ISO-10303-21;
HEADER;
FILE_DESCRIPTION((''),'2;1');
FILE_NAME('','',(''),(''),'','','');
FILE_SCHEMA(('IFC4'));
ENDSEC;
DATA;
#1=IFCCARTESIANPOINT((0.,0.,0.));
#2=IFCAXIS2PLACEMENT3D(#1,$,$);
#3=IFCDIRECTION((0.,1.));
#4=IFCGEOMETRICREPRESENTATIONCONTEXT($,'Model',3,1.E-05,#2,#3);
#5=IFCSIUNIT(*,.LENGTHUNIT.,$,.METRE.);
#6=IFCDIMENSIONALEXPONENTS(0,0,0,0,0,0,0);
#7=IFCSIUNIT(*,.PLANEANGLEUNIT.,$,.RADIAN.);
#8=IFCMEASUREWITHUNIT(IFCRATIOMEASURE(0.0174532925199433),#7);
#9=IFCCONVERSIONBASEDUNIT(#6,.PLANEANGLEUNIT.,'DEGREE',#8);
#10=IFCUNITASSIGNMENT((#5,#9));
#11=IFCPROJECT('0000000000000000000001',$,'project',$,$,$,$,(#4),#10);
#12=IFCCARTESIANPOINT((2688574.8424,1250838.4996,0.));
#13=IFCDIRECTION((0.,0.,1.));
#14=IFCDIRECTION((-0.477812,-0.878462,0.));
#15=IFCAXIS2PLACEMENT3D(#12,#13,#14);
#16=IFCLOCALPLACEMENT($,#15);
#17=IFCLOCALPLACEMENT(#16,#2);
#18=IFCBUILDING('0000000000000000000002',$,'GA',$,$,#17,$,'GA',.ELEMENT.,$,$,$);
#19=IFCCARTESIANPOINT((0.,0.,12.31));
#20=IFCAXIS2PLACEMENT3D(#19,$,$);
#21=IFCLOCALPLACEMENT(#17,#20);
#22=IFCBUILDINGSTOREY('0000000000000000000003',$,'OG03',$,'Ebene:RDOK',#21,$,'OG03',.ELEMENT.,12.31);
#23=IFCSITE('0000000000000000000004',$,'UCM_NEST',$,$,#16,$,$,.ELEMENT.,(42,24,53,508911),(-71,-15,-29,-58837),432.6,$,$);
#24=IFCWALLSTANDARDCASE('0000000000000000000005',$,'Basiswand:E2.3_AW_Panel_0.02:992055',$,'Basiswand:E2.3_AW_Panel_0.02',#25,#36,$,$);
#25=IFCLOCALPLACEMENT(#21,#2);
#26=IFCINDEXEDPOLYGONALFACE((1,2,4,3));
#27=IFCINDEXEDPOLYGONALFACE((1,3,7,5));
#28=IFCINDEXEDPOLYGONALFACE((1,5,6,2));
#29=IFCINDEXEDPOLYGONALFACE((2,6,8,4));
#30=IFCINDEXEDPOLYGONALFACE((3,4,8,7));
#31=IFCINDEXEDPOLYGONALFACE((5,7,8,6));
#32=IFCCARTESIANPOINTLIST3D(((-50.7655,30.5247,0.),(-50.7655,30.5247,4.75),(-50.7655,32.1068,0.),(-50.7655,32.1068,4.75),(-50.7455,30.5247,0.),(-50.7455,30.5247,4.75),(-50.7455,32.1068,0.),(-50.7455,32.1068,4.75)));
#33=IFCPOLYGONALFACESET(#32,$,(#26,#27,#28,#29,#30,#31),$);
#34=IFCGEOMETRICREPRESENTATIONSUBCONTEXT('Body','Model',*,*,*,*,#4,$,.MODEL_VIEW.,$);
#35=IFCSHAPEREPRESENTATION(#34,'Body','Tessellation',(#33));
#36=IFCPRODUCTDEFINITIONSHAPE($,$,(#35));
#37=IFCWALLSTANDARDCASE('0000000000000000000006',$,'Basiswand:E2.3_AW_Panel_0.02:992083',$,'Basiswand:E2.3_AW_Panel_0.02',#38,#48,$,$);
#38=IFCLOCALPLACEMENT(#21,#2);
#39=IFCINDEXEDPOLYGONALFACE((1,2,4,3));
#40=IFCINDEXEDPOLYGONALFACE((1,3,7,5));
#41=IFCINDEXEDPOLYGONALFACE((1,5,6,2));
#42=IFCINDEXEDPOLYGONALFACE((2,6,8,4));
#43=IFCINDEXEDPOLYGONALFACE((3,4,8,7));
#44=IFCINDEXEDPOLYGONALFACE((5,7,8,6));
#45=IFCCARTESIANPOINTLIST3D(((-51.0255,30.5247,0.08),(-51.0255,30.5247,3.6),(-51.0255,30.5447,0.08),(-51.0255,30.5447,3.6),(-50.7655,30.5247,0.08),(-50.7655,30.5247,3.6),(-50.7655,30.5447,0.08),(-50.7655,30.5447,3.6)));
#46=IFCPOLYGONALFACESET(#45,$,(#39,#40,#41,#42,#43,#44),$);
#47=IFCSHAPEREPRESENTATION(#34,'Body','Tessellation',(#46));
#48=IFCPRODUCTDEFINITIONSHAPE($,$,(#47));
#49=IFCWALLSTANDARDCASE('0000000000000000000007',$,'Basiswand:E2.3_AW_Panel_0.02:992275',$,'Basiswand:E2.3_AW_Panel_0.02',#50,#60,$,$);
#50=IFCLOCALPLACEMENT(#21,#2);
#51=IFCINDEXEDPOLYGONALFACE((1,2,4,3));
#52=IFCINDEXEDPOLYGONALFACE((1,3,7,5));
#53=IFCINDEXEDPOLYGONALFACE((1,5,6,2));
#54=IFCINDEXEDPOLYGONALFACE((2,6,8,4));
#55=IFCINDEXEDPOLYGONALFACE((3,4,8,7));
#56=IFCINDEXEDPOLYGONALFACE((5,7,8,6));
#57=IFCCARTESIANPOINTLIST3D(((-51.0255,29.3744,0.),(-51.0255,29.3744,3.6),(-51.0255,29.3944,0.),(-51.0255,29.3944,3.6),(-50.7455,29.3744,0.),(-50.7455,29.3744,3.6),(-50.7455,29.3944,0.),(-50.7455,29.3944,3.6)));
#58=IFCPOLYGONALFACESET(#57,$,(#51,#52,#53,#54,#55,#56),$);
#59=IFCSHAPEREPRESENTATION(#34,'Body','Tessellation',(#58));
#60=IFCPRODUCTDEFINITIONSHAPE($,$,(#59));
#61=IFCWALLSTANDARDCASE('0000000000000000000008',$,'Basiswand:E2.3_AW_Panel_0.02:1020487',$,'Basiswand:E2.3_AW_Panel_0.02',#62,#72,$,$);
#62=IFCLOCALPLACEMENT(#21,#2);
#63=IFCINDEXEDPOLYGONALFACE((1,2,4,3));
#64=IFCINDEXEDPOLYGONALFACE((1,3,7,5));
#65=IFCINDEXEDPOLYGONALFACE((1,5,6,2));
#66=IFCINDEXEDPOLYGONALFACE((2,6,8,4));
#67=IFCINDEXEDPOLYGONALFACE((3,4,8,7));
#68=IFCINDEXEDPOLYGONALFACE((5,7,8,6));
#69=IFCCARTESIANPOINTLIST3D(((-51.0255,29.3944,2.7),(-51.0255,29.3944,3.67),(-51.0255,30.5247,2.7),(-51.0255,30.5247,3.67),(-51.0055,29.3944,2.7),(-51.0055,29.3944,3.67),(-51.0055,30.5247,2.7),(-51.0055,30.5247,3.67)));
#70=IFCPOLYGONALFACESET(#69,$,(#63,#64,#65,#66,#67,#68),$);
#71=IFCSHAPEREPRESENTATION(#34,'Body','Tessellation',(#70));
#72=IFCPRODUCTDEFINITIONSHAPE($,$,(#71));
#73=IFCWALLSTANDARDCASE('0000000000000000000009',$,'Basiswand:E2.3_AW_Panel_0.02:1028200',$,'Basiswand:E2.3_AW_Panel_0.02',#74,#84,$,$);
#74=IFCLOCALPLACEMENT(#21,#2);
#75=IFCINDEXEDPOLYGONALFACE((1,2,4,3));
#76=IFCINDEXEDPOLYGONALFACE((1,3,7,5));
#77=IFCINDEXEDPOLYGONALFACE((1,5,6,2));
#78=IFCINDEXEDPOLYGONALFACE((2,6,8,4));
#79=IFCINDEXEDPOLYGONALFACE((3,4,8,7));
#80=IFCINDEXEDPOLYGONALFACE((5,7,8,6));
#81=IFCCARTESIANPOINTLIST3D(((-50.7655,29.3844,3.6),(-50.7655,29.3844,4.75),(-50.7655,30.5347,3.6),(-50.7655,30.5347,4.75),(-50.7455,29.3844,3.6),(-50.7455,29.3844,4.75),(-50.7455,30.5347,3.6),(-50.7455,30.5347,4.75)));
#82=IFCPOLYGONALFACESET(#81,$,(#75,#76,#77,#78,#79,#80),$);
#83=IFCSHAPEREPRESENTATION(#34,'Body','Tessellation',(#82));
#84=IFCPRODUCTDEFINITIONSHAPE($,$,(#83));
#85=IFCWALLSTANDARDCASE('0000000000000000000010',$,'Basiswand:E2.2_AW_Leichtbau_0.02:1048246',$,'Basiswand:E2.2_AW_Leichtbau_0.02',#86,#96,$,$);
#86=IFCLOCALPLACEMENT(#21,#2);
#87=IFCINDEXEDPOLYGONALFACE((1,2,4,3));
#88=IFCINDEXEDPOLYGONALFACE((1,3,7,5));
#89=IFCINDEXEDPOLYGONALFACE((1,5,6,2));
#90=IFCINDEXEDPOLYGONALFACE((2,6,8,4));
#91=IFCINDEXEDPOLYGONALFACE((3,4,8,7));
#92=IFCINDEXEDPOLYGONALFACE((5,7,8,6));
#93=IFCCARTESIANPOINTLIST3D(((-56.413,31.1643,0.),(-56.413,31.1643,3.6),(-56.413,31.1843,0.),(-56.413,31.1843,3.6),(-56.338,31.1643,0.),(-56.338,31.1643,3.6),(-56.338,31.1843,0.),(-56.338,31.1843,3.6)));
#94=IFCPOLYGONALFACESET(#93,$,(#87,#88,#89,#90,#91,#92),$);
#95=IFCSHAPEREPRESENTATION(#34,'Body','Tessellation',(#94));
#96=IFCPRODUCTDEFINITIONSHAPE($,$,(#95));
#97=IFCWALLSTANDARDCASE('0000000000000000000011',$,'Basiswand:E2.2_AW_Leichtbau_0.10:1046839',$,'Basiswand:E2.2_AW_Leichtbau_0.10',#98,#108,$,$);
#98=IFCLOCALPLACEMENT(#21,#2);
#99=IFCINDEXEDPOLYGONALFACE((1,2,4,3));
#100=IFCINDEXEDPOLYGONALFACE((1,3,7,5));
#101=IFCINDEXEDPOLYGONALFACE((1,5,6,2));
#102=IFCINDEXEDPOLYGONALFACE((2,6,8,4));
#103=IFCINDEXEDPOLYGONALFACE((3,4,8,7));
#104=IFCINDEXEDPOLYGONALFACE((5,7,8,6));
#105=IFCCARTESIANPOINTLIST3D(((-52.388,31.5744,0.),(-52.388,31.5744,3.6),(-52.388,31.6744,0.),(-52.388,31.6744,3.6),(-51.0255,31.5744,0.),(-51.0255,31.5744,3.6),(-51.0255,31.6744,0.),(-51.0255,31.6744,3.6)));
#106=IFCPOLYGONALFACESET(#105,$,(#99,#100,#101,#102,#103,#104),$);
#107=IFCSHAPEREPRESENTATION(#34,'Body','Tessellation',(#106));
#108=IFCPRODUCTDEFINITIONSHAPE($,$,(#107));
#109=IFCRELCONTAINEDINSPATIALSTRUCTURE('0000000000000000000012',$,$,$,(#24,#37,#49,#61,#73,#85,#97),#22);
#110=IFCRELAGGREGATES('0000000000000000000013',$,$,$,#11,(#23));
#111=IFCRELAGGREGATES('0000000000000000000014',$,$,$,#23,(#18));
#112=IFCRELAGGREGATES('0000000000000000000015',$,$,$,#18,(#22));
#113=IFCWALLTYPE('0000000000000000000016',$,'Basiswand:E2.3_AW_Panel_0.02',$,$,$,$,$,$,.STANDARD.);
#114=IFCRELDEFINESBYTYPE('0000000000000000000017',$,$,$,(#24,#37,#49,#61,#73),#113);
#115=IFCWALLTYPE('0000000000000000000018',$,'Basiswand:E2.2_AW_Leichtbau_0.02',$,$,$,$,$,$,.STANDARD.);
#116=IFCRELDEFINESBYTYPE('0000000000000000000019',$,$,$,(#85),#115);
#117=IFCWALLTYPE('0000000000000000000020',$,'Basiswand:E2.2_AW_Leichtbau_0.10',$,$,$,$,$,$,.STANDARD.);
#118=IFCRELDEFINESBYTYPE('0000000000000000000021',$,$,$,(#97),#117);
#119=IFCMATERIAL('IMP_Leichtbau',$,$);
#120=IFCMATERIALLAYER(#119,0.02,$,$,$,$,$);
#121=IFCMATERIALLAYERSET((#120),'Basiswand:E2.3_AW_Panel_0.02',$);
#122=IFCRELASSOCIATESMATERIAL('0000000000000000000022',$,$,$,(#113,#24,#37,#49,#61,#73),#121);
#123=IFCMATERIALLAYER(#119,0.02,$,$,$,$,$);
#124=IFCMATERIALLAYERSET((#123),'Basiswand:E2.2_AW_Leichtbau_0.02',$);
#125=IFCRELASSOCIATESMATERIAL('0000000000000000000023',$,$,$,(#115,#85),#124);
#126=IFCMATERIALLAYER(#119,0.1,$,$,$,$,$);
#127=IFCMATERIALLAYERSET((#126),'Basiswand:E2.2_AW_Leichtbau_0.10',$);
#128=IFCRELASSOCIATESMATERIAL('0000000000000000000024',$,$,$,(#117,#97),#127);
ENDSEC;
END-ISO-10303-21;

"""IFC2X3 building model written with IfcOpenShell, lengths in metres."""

from ifc_helpers import new_model, entity, si_unit, converted_unit, direction, frame, frame_2d, origin, place, context, subcontext, project, spatial, polyline, rectangle, extrude, clip, bounded_halfspace, material, layer, layer_set, layer_usage, type_object, element, save


model = new_model("IFC2X3")

# Units and contexts
model_context = context("Model", 3, precision=1e-05, world=origin(), true_north=direction((0.0, 1.0)))
body_context = subcontext(model_context, "Body", "Model", "MODEL_VIEW")
ifc_project = project(units=[si_unit("LENGTHUNIT", "METRE"), converted_unit("PLANEANGLEUNIT", "DEGREE", entity("IfcRatioMeasure", 0.0174532925199433), si_unit("PLANEANGLEUNIT", "RADIAN"), dimensions=[0, 0, 0, 0, 0, 0, 0])], contexts=[model_context])

# Site, building, storey
site_placement = place(None, frame((2688574.8424, 1250838.4996, 0.0), z_axis=(0.0, 0.0, 1.0), x_axis=(-0.477812, -0.878462, 0.0)))
site = spatial("IfcSite", under=ifc_project, at=site_placement, Name="UCM_NEST", CompositionType="ELEMENT", RefLatitude=(42, 24, 53, 508911), RefLongitude=(-71, -15, -29, -58837), RefElevation=432.6)
building_placement = place(site_placement, origin())
building = spatial("IfcBuilding", under=site, at=building_placement, Name="GA", LongName="GA", CompositionType="ELEMENT")
storey_placement = place(building_placement, frame((0.0, 0.0, 12.31)))
storey = spatial("IfcBuildingStorey", under=building, at=storey_placement, Name="OG03", ObjectType="Ebene:RDOK", LongName="OG03", CompositionType="ELEMENT", Elevation=12.31)

# Walls
ifc_material_1 = material(Name="IMP_Leichtbau")
ifc_layer_1 = layer(ifc_material_1, 0.02)
ifc_layer_set_1 = layer_set([ifc_layer_1], Name="Basiswand:E2.3_AW_Panel_0.02")
wall_type_1 = type_object("IfcWallType", Name="Basiswand:E2.3_AW_Panel_0.02", PredefinedType="STANDARD", material=ifc_layer_set_1)
ifc_layer_usage_1 = layer_usage(ifc_layer_set_1, "AXIS2", "NEGATIVE", 0.01)
wall_1_placement = place(storey_placement, frame((-50.7555, 32.1068, 0.0), z_axis=(0.0, 0.0, 1.0), x_axis=(0.0, -1.0, 0.0)))
element("IfcWallStandardCase", 1, at=wall_1_placement, inside=storey, type_object=wall_type_1, material=ifc_layer_usage_1, Name="Basiswand:E2.3_AW_Panel_0.02:992055", ObjectType="Basiswand:E2.3_AW_Panel_0.02", context=body_context, shape_type="SweptSolid", body=[
    extrude(rectangle(XDim=1.5821, YDim=0.02, at=frame_2d((0.791, 0.0), x_axis=(-1.0, 0.0))), origin(), (0.0, 0.0, 1.0), 4.75),
])
ifc_layer_usage_2 = layer_usage(ifc_layer_set_1, "AXIS2", "NEGATIVE", 0.01)
wall_2_placement = place(storey_placement, frame((-50.7655, 30.5347, 0.08), z_axis=(0.0, 0.0, 1.0), x_axis=(-1.0, 0.0, 0.0)))
element("IfcWallStandardCase", 2, at=wall_2_placement, inside=storey, type_object=wall_type_1, material=ifc_layer_usage_2, Name="Basiswand:E2.3_AW_Panel_0.02:992083", ObjectType="Basiswand:E2.3_AW_Panel_0.02", context=body_context, shape_type="Clipping", body=[
    clip(extrude(rectangle(XDim=0.26, YDim=0.02, at=frame_2d((0.13, 0.0), x_axis=(-1.0, 0.0))), origin(), (0.0, 0.0, 1.0), 3.52), bounded_halfspace(frame((0.26, -0.01, 0.0)), True, frame((0.26, -0.01, 0.0)), polyline([(0.0, 0.0), (0.0, 0.02), (-0.26, 0.02), (-0.26, 0.0), (0.0, 0.0)]))),
])
ifc_layer_usage_3 = layer_usage(ifc_layer_set_1, "AXIS2", "NEGATIVE", 0.01)
wall_3_placement = place(storey_placement, frame((-51.0255, 29.3844, 0.0)))
element("IfcWallStandardCase", 3, at=wall_3_placement, inside=storey, type_object=wall_type_1, material=ifc_layer_usage_3, Name="Basiswand:E2.3_AW_Panel_0.02:992275", ObjectType="Basiswand:E2.3_AW_Panel_0.02", context=body_context, shape_type="SweptSolid", body=[
    extrude(rectangle(XDim=0.28, YDim=0.02, at=frame_2d((0.14, 0.0), x_axis=(-1.0, 0.0))), origin(), (0.0, 0.0, 1.0), 3.6),
])
ifc_layer_usage_4 = layer_usage(ifc_layer_set_1, "AXIS2", "NEGATIVE", 0.01)
wall_4_placement = place(storey_placement, frame((-51.0155, 30.5247, 2.7), z_axis=(0.0, 0.0, 1.0), x_axis=(0.0, -1.0, 0.0)))
element("IfcWallStandardCase", 4, at=wall_4_placement, inside=storey, type_object=wall_type_1, material=ifc_layer_usage_4, Name="Basiswand:E2.3_AW_Panel_0.02:1020487", ObjectType="Basiswand:E2.3_AW_Panel_0.02", context=body_context, shape_type="SweptSolid", body=[
    extrude(rectangle(XDim=1.1302, YDim=0.02, at=frame_2d((0.5651, 0.0), x_axis=(-1.0, 0.0))), origin(), (0.0, 0.0, 1.0), 0.97),
])
ifc_layer_usage_5 = layer_usage(ifc_layer_set_1, "AXIS2", "NEGATIVE", 0.01)
wall_5_placement = place(storey_placement, frame((-50.7555, 29.3844, 3.6), z_axis=(0.0, 0.0, 1.0), x_axis=(0.0, 1.0, 0.0)))
element("IfcWallStandardCase", 5, at=wall_5_placement, inside=storey, type_object=wall_type_1, material=ifc_layer_usage_5, Name="Basiswand:E2.3_AW_Panel_0.02:1028200", ObjectType="Basiswand:E2.3_AW_Panel_0.02", context=body_context, shape_type="SweptSolid", body=[
    extrude(rectangle(XDim=1.1502, YDim=0.02, at=frame_2d((0.5751, 0.0), x_axis=(-1.0, 0.0))), origin(), (0.0, 0.0, 1.0), 1.15),
])

# Walls
ifc_layer_2 = layer(ifc_material_1, 0.02)
ifc_layer_set_2 = layer_set([ifc_layer_2], Name="Basiswand:E2.2_AW_Leichtbau_0.02")
ifc_layer_usage_6 = layer_usage(ifc_layer_set_2, "AXIS2", "NEGATIVE", 0.01)
wall_type_2 = type_object("IfcWallType", Name="Basiswand:E2.2_AW_Leichtbau_0.02", PredefinedType="STANDARD", material=ifc_layer_set_2)
wall_6_placement = place(storey_placement, frame((-56.338, 31.1743, 0.0), z_axis=(0.0, 0.0, 1.0), x_axis=(-1.0, 0.0, 0.0)))
element("IfcWallStandardCase", 6, at=wall_6_placement, inside=storey, type_object=wall_type_2, material=ifc_layer_usage_6, Name="Basiswand:E2.2_AW_Leichtbau_0.02:1048246", ObjectType="Basiswand:E2.2_AW_Leichtbau_0.02", context=body_context, shape_type="SweptSolid", body=[
    extrude(rectangle(XDim=0.075, YDim=0.02, at=frame_2d((0.0375, 0.0), x_axis=(-1.0, 0.0))), origin(), (0.0, 0.0, 1.0), 3.6),
])
ifc_layer_3 = layer(ifc_material_1, 0.1)
ifc_layer_set_3 = layer_set([ifc_layer_3], Name="Basiswand:E2.2_AW_Leichtbau_0.10")
ifc_layer_usage_7 = layer_usage(ifc_layer_set_3, "AXIS2", "NEGATIVE", 0.05)
wall_type_3 = type_object("IfcWallType", Name="Basiswand:E2.2_AW_Leichtbau_0.10", PredefinedType="STANDARD", material=ifc_layer_set_3)
wall_7_placement = place(storey_placement, frame((-51.0255, 31.6244, 0.0), z_axis=(0.0, 0.0, 1.0), x_axis=(-1.0, 0.0, 0.0)))
element("IfcWallStandardCase", 7, at=wall_7_placement, inside=storey, type_object=wall_type_3, material=ifc_layer_usage_7, Name="Basiswand:E2.2_AW_Leichtbau_0.10:1046839", ObjectType="Basiswand:E2.2_AW_Leichtbau_0.10", context=body_context, shape_type="SweptSolid", body=[
    extrude(rectangle(XDim=1.3625, YDim=0.1, at=frame_2d((0.6812, 0.0), x_axis=(-1.0, 0.0))), origin(), (0.0, 0.0, 1.0), 3.6),
])

save(model, "model.ifc")
